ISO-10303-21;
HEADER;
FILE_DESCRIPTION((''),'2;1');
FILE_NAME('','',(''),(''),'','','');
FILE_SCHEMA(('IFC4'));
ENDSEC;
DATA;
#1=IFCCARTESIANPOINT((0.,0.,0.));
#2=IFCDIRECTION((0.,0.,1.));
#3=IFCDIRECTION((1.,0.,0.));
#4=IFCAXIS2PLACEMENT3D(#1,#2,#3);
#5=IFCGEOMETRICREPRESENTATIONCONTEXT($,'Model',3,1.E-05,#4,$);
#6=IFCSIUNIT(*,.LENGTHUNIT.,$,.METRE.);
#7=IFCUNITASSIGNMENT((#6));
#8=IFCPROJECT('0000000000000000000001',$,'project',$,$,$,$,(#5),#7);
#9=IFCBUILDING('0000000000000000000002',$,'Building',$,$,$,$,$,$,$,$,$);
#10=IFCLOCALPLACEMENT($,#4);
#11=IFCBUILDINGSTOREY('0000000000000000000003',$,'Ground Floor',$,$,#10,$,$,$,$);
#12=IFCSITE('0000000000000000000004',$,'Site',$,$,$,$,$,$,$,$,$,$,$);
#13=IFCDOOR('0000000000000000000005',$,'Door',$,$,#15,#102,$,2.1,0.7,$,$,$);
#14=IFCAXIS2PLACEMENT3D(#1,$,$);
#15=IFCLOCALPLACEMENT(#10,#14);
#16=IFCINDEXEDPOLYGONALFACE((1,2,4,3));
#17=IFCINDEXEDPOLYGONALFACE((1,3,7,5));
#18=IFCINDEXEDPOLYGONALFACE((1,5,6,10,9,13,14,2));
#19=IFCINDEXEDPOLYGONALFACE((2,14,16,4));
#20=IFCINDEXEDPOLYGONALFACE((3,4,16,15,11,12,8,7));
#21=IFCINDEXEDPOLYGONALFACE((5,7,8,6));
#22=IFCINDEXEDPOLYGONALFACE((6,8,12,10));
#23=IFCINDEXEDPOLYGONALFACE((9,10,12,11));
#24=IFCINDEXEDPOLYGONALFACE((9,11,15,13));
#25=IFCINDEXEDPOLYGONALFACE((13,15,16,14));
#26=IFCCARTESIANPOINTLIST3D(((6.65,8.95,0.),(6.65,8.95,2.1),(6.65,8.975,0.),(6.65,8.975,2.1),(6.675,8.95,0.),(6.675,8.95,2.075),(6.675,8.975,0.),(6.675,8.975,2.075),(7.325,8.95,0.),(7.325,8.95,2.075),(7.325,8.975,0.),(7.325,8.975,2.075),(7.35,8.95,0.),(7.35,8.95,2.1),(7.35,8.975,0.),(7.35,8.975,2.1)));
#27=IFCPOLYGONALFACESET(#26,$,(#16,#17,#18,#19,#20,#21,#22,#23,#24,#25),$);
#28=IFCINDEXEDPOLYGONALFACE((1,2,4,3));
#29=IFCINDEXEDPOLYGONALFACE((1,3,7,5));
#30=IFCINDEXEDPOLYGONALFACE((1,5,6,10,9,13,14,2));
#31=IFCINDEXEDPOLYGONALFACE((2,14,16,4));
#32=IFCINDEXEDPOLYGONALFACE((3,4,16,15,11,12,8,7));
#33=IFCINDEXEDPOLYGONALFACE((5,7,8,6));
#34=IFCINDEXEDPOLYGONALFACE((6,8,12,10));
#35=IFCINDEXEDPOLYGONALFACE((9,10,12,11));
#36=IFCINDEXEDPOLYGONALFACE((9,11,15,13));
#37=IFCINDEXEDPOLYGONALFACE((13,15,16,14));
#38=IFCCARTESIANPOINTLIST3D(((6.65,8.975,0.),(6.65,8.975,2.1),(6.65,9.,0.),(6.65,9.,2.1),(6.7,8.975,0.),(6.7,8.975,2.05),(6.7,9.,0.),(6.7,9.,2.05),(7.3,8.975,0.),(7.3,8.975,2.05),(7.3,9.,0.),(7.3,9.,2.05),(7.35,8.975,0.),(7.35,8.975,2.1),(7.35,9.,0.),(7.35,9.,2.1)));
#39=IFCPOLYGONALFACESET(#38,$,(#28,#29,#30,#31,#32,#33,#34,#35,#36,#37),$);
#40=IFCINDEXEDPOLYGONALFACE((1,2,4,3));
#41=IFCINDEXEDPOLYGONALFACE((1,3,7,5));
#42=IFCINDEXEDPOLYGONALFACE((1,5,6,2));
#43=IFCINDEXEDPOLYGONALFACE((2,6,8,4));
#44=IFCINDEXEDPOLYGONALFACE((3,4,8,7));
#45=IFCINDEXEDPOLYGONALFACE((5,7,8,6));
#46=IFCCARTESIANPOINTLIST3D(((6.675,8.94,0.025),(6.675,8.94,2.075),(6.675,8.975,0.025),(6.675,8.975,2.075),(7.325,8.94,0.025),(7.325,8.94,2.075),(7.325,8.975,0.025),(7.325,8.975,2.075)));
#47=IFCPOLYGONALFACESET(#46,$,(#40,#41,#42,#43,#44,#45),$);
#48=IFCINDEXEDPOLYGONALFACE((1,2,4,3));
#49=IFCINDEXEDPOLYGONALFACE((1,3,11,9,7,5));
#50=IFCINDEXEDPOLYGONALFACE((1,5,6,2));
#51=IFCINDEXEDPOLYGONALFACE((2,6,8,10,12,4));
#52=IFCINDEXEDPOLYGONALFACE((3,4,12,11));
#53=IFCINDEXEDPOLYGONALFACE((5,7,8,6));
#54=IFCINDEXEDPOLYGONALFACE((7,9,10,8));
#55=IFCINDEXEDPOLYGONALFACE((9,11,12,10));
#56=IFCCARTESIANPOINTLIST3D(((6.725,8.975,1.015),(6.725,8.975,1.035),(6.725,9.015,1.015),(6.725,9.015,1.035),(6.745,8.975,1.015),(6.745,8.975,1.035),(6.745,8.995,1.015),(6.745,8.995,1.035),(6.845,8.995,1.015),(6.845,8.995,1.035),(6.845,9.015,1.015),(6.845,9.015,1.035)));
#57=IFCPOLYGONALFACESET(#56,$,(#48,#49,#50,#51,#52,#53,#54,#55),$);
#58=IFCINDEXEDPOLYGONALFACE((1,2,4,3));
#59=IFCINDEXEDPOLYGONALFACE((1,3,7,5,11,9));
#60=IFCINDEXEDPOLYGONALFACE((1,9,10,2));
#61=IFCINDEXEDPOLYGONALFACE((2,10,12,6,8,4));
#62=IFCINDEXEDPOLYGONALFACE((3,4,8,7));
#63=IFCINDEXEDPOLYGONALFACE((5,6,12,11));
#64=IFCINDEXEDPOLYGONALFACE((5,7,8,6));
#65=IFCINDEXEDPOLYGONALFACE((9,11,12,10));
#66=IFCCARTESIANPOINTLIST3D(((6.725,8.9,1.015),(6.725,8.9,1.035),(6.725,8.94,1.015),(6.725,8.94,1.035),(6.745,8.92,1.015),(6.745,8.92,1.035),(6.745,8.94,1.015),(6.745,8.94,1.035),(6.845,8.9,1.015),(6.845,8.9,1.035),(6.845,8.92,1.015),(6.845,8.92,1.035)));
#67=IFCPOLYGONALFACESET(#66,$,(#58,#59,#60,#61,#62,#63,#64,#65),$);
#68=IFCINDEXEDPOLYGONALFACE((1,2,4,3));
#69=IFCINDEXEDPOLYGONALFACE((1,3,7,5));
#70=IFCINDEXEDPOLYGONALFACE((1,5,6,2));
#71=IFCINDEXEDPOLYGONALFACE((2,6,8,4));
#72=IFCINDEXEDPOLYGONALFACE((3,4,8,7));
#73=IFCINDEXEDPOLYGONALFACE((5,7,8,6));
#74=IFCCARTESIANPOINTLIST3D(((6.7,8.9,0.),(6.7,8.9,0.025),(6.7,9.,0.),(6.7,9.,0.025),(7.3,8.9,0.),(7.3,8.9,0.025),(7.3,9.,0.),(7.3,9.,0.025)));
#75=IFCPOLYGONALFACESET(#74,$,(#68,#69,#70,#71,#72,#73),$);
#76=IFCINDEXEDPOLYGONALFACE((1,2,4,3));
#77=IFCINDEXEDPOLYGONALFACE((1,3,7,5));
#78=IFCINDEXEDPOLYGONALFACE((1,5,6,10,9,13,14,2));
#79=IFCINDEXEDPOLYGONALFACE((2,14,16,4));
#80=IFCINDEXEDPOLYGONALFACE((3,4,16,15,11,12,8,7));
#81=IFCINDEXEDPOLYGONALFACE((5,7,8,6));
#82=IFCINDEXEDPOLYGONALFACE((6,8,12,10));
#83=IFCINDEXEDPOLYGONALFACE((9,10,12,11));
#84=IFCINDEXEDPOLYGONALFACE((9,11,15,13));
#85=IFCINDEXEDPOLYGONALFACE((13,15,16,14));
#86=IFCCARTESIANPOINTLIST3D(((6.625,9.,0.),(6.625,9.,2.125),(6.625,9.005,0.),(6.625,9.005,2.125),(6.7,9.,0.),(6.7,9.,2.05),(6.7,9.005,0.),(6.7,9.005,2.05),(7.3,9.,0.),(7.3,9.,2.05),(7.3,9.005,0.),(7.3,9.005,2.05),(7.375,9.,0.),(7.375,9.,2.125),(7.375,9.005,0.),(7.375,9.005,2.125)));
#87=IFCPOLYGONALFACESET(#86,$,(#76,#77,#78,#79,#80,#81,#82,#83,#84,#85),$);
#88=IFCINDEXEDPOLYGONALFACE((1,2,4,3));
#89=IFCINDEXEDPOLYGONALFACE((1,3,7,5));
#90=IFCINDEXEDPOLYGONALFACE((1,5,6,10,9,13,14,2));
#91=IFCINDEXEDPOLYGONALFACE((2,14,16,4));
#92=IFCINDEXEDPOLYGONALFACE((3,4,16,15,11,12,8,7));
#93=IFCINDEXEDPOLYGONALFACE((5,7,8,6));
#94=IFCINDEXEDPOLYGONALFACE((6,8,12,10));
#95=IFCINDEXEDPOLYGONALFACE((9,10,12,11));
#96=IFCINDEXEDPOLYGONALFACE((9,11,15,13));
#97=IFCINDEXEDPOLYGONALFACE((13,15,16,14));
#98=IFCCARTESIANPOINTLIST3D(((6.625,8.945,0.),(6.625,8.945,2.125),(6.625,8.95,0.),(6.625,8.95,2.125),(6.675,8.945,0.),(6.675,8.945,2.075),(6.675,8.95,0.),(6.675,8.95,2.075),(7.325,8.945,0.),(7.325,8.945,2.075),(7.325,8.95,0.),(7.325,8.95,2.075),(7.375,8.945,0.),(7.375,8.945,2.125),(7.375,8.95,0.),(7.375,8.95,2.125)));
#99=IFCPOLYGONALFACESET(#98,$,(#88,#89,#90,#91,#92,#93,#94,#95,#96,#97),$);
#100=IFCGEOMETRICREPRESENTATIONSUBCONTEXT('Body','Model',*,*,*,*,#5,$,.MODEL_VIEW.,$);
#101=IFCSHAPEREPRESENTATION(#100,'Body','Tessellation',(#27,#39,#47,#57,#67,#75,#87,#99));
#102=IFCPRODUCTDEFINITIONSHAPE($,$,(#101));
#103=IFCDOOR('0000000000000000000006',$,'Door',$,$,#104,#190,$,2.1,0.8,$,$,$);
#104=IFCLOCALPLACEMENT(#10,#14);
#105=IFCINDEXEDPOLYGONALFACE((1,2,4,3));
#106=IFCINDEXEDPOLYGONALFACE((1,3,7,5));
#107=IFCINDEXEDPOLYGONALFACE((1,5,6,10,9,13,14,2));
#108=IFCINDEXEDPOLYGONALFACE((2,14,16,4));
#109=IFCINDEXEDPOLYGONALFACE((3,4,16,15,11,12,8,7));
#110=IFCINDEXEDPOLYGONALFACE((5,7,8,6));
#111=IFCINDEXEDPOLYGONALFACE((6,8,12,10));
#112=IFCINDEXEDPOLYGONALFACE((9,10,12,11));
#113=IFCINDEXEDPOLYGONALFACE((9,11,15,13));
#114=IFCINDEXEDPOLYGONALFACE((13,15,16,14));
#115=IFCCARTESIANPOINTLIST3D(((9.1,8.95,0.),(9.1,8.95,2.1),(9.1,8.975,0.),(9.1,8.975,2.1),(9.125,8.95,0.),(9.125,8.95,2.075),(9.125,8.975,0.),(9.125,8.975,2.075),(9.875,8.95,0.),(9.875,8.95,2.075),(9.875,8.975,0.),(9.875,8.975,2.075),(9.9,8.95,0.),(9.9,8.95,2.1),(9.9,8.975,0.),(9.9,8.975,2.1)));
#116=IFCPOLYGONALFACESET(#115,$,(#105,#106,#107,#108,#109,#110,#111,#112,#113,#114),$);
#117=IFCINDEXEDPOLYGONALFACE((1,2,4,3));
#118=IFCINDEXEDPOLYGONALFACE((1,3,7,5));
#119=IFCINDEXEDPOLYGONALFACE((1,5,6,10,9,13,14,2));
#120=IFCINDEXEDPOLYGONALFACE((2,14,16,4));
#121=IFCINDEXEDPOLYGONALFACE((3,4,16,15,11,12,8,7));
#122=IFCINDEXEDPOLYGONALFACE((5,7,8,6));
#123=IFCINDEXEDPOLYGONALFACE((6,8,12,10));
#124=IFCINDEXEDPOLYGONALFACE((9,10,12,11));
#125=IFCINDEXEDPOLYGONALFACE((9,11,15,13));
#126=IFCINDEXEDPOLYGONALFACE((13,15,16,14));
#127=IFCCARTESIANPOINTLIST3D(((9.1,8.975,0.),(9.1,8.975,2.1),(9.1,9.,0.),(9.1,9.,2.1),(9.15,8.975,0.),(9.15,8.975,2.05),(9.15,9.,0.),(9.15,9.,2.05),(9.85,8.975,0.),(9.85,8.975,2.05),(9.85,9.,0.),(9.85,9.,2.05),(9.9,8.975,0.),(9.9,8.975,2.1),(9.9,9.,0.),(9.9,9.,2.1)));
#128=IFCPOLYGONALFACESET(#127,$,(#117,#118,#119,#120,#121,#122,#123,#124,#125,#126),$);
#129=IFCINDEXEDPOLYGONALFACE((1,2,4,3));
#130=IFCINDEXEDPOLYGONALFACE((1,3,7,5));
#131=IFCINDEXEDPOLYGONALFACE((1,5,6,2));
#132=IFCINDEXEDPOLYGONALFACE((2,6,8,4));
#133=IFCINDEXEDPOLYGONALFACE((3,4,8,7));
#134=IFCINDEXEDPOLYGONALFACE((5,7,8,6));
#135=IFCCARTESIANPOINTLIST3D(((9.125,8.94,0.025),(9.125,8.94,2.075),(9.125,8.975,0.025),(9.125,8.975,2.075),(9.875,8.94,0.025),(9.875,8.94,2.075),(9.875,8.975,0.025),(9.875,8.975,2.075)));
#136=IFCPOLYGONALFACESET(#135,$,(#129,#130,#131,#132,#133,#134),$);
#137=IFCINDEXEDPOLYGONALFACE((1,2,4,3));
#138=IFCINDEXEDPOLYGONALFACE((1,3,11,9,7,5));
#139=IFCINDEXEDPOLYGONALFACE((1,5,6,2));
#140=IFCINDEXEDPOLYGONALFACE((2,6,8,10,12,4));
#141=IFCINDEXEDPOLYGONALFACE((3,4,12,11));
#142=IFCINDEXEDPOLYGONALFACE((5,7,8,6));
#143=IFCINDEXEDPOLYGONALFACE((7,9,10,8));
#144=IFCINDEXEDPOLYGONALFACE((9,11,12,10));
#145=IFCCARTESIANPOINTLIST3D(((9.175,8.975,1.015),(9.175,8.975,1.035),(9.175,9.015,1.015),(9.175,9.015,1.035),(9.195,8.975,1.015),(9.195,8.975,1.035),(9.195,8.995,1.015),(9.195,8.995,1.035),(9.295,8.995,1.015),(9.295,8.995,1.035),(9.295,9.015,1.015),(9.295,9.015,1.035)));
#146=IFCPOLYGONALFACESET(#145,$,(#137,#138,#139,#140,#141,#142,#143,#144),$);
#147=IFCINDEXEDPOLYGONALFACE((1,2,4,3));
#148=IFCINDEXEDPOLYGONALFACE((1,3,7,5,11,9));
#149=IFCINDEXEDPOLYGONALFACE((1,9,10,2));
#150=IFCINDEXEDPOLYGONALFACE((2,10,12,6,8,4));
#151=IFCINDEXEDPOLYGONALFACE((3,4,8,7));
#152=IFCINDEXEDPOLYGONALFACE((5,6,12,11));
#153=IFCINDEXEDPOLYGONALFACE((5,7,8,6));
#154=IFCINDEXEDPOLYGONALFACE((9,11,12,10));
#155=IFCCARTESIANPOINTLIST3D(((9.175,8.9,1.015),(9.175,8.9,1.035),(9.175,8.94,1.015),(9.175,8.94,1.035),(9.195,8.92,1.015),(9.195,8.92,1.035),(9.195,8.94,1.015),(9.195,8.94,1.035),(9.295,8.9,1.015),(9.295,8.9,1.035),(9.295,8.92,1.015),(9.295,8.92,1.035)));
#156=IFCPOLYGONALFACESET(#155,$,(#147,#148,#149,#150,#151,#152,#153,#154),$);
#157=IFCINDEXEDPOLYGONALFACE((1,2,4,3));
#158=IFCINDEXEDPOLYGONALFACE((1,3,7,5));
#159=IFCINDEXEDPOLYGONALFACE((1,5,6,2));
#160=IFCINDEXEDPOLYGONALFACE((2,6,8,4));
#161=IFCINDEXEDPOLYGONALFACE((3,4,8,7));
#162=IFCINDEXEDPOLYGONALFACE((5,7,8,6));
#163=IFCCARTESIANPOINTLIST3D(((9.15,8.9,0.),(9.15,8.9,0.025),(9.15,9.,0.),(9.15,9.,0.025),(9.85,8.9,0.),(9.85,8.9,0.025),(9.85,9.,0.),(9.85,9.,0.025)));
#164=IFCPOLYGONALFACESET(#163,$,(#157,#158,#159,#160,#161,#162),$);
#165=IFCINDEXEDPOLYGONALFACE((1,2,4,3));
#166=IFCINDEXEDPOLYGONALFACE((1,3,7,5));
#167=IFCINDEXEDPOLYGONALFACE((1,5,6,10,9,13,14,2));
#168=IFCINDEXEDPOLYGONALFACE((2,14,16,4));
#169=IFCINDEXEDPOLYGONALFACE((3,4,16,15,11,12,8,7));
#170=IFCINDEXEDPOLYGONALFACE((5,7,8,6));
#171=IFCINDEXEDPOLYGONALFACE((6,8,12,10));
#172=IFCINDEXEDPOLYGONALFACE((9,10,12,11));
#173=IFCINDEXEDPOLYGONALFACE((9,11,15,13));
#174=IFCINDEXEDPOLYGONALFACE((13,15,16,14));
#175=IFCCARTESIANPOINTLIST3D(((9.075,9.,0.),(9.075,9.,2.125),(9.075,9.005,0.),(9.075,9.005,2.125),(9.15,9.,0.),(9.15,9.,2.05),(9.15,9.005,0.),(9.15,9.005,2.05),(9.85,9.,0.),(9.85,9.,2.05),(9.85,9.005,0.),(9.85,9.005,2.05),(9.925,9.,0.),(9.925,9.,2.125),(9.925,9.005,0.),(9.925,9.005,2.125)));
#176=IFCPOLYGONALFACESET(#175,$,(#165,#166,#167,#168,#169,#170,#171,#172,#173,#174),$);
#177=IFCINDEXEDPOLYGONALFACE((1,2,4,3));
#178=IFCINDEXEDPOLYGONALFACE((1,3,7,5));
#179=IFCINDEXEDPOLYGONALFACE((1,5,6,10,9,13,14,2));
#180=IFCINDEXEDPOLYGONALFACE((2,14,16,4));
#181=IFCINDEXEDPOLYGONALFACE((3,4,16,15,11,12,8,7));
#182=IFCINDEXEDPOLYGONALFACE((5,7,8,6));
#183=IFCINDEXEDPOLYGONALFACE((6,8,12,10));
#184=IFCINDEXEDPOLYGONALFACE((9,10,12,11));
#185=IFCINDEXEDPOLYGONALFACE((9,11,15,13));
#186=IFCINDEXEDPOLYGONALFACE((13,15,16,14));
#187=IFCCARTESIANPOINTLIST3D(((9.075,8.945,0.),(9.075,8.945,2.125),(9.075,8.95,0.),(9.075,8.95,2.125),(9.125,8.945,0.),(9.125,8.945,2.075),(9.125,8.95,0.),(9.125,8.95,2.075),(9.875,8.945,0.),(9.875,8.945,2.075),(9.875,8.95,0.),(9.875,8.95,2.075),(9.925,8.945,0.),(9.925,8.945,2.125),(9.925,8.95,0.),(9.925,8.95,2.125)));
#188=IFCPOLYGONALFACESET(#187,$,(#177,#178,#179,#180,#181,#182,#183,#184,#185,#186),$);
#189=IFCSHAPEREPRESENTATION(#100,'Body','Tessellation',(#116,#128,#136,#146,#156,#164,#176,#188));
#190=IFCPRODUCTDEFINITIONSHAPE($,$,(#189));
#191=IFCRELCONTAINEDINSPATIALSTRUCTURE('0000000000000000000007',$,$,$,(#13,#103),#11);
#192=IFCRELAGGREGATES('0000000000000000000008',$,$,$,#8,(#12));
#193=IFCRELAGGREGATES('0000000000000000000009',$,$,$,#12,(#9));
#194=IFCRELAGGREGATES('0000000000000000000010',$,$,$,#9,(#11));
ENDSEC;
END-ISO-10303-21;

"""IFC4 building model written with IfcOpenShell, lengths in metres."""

from ifc_helpers import new_model, si_unit, frame, origin_with_axes, place, context, subcontext, project, spatial, line, indexed_curve, outline, extrude, element, save


model = new_model("IFC4")

# Units and contexts
model_context = context("Model", 3, precision=1e-05, world=origin_with_axes())
body_context = subcontext(model_context, "Body", "Model", "MODEL_VIEW")
ifc_project = project(units=[si_unit("LENGTHUNIT", "METRE")], contexts=[model_context])

# Site, building, storey
site = spatial("IfcSite", under=ifc_project, Name="Site")
building = spatial("IfcBuilding", under=site, Name="Building")
storey_placement = place(None, origin_with_axes())
storey = spatial("IfcBuildingStorey", under=building, at=storey_placement, Name="Ground Floor")

# Doors
door_1_placement = place(storey_placement, frame((7.35, 9.0, 0.0), z_axis=(0.0, 0.0, 1.0), x_axis=(-1.0, 0.0, 0.0)))
element("IfcDoor", 1, at=door_1_placement, inside=storey, Name="Door", OverallHeight=2.1, OverallWidth=0.7, context=body_context, shape_type="SweptSolid", body=[
    extrude(outline(indexed_curve([(0.0, 0.0), (0.0, 2.1), (0.7, 2.1), (0.7, 0.0), (0.675, 0.0), (0.675, 2.075), (0.025, 2.075), (0.025, 0.0)], segments=[line(1, 2, 3, 4, 5, 6, 7, 8, 1)])), frame((0.0, 0.025, 0.0), z_axis=(0.0, -1.0, 0.0), x_axis=(1.0, 0.0, 0.0)), (0.0, 0.0, -1.0), 0.025),
    extrude(outline(indexed_curve([(0.0, 0.0), (0.0, 2.1), (0.7, 2.1), (0.7, 0.0), (0.65, 0.0), (0.65, 2.05), (0.05, 2.05), (0.05, 0.0)], segments=[line(1, 2, 3, 4, 5, 6, 7, 8, 1)])), frame((0.0, 0.0, 0.0), z_axis=(0.0, -1.0, 0.0), x_axis=(1.0, 0.0, 0.0)), (0.0, 0.0, -1.0), 0.025),
    extrude(outline(indexed_curve([(0.0, 0.0), (0.65, 0.0), (0.65, 0.035), (0.0, 0.035)], segments=[line(1, 2, 3, 4, 1)])), frame((0.025, 0.025, 0.025), z_axis=(0.0, 0.0, 1.0), x_axis=(1.0, 0.0, 0.0)), (0.0, 0.0, 1.0), 2.05),
    extrude(outline(indexed_curve([(0.0, 0.0), (0.0, -0.04), (-0.12, -0.04), (-0.12, -0.02), (-0.02, -0.02), (-0.02, 0.0)], segments=[line(1, 2, 3, 4, 5, 6, 1)])), frame((0.625, 0.025, 1.015), z_axis=(0.0, 0.0, 1.0), x_axis=(1.0, 0.0, 0.0)), (0.0, 0.0, 1.0), 0.02),
    extrude(outline(indexed_curve([(0.0, 0.0), (0.0, 0.04), (-0.12, 0.04), (-0.12, 0.02), (-0.02, 0.02), (-0.02, 0.0)], segments=[line(1, 2, 3, 4, 5, 6, 1)])), frame((0.625, 0.06, 1.015), z_axis=(0.0, 0.0, 1.0), x_axis=(1.0, 0.0, 0.0)), (0.0, 0.0, 1.0), 0.02),
    extrude(outline(indexed_curve([(0.0, 0.0), (0.6, 0.0), (0.6, 0.1), (0.0, 0.1)], segments=[line(1, 2, 3, 4, 1)])), frame((0.05, 0.0, 0.0), z_axis=(0.0, 0.0, 1.0), x_axis=(1.0, 0.0, 0.0)), (0.0, 0.0, 1.0), 0.025),
    extrude(outline(indexed_curve([(0.0, 0.0), (0.0, 2.125), (0.75, 2.125), (0.75, 0.0), (0.675, 0.0), (0.675, 2.05), (0.075, 2.05), (0.075, 0.0)], segments=[line(1, 2, 3, 4, 5, 6, 7, 8, 1)])), frame((-0.025, -0.005, 0.0), z_axis=(0.0, -1.0, 0.0), x_axis=(1.0, 0.0, 0.0)), (0.0, 0.0, -1.0), 0.005),
    extrude(outline(indexed_curve([(0.0, 0.0), (0.0, 2.125), (0.75, 2.125), (0.75, 0.0), (0.7, 0.0), (0.7, 2.075), (0.05, 2.075), (0.05, 0.0)], segments=[line(1, 2, 3, 4, 5, 6, 7, 8, 1)])), frame((-0.025, 0.05, 0.0), z_axis=(0.0, -1.0, 0.0), x_axis=(1.0, 0.0, 0.0)), (0.0, 0.0, -1.0), 0.005),
])
door_2_placement = place(storey_placement, frame((9.9, 9.0, 0.0), z_axis=(0.0, 0.0, 1.0), x_axis=(-1.0, 0.0, 0.0)))
element("IfcDoor", 2, at=door_2_placement, inside=storey, Name="Door", OverallHeight=2.1, OverallWidth=0.8, context=body_context, shape_type="SweptSolid", body=[
    extrude(outline(indexed_curve([(0.0, 0.0), (0.0, 2.1), (0.8, 2.1), (0.8, 0.0), (0.775, 0.0), (0.775, 2.075), (0.025, 2.075), (0.025, 0.0)], segments=[line(1, 2, 3, 4, 5, 6, 7, 8, 1)])), frame((0.0, 0.025, 0.0), z_axis=(0.0, -1.0, 0.0), x_axis=(1.0, 0.0, 0.0)), (0.0, 0.0, -1.0), 0.025),
    extrude(outline(indexed_curve([(0.0, 0.0), (0.0, 2.1), (0.8, 2.1), (0.8, 0.0), (0.75, 0.0), (0.75, 2.05), (0.05, 2.05), (0.05, 0.0)], segments=[line(1, 2, 3, 4, 5, 6, 7, 8, 1)])), frame((0.0, 0.0, 0.0), z_axis=(0.0, -1.0, 0.0), x_axis=(1.0, 0.0, 0.0)), (0.0, 0.0, -1.0), 0.025),
    extrude(outline(indexed_curve([(0.0, 0.0), (0.75, 0.0), (0.75, 0.035), (0.0, 0.035)], segments=[line(1, 2, 3, 4, 1)])), frame((0.025, 0.025, 0.025), z_axis=(0.0, 0.0, 1.0), x_axis=(1.0, 0.0, 0.0)), (0.0, 0.0, 1.0), 2.05),
    extrude(outline(indexed_curve([(0.0, 0.0), (0.0, -0.04), (-0.12, -0.04), (-0.12, -0.02), (-0.02, -0.02), (-0.02, 0.0)], segments=[line(1, 2, 3, 4, 5, 6, 1)])), frame((0.725, 0.025, 1.015), z_axis=(0.0, 0.0, 1.0), x_axis=(1.0, 0.0, 0.0)), (0.0, 0.0, 1.0), 0.02),
    extrude(outline(indexed_curve([(0.0, 0.0), (0.0, 0.04), (-0.12, 0.04), (-0.12, 0.02), (-0.02, 0.02), (-0.02, 0.0)], segments=[line(1, 2, 3, 4, 5, 6, 1)])), frame((0.725, 0.06, 1.015), z_axis=(0.0, 0.0, 1.0), x_axis=(1.0, 0.0, 0.0)), (0.0, 0.0, 1.0), 0.02),
    extrude(outline(indexed_curve([(0.0, 0.0), (0.7, 0.0), (0.7, 0.1), (0.0, 0.1)], segments=[line(1, 2, 3, 4, 1)])), frame((0.05, 0.0, 0.0), z_axis=(0.0, 0.0, 1.0), x_axis=(1.0, 0.0, 0.0)), (0.0, 0.0, 1.0), 0.025),
    extrude(outline(indexed_curve([(0.0, 0.0), (0.0, 2.125), (0.85, 2.125), (0.85, 0.0), (0.775, 0.0), (0.775, 2.05), (0.075, 2.05), (0.075, 0.0)], segments=[line(1, 2, 3, 4, 5, 6, 7, 8, 1)])), frame((-0.025, -0.005, 0.0), z_axis=(0.0, -1.0, 0.0), x_axis=(1.0, 0.0, 0.0)), (0.0, 0.0, -1.0), 0.005),
    extrude(outline(indexed_curve([(0.0, 0.0), (0.0, 2.125), (0.85, 2.125), (0.85, 0.0), (0.8, 0.0), (0.8, 2.075), (0.05, 2.075), (0.05, 0.0)], segments=[line(1, 2, 3, 4, 5, 6, 7, 8, 1)])), frame((-0.025, 0.05, 0.0), z_axis=(0.0, -1.0, 0.0), x_axis=(1.0, 0.0, 0.0)), (0.0, 0.0, -1.0), 0.005),
])

save(model, "model.ifc")
